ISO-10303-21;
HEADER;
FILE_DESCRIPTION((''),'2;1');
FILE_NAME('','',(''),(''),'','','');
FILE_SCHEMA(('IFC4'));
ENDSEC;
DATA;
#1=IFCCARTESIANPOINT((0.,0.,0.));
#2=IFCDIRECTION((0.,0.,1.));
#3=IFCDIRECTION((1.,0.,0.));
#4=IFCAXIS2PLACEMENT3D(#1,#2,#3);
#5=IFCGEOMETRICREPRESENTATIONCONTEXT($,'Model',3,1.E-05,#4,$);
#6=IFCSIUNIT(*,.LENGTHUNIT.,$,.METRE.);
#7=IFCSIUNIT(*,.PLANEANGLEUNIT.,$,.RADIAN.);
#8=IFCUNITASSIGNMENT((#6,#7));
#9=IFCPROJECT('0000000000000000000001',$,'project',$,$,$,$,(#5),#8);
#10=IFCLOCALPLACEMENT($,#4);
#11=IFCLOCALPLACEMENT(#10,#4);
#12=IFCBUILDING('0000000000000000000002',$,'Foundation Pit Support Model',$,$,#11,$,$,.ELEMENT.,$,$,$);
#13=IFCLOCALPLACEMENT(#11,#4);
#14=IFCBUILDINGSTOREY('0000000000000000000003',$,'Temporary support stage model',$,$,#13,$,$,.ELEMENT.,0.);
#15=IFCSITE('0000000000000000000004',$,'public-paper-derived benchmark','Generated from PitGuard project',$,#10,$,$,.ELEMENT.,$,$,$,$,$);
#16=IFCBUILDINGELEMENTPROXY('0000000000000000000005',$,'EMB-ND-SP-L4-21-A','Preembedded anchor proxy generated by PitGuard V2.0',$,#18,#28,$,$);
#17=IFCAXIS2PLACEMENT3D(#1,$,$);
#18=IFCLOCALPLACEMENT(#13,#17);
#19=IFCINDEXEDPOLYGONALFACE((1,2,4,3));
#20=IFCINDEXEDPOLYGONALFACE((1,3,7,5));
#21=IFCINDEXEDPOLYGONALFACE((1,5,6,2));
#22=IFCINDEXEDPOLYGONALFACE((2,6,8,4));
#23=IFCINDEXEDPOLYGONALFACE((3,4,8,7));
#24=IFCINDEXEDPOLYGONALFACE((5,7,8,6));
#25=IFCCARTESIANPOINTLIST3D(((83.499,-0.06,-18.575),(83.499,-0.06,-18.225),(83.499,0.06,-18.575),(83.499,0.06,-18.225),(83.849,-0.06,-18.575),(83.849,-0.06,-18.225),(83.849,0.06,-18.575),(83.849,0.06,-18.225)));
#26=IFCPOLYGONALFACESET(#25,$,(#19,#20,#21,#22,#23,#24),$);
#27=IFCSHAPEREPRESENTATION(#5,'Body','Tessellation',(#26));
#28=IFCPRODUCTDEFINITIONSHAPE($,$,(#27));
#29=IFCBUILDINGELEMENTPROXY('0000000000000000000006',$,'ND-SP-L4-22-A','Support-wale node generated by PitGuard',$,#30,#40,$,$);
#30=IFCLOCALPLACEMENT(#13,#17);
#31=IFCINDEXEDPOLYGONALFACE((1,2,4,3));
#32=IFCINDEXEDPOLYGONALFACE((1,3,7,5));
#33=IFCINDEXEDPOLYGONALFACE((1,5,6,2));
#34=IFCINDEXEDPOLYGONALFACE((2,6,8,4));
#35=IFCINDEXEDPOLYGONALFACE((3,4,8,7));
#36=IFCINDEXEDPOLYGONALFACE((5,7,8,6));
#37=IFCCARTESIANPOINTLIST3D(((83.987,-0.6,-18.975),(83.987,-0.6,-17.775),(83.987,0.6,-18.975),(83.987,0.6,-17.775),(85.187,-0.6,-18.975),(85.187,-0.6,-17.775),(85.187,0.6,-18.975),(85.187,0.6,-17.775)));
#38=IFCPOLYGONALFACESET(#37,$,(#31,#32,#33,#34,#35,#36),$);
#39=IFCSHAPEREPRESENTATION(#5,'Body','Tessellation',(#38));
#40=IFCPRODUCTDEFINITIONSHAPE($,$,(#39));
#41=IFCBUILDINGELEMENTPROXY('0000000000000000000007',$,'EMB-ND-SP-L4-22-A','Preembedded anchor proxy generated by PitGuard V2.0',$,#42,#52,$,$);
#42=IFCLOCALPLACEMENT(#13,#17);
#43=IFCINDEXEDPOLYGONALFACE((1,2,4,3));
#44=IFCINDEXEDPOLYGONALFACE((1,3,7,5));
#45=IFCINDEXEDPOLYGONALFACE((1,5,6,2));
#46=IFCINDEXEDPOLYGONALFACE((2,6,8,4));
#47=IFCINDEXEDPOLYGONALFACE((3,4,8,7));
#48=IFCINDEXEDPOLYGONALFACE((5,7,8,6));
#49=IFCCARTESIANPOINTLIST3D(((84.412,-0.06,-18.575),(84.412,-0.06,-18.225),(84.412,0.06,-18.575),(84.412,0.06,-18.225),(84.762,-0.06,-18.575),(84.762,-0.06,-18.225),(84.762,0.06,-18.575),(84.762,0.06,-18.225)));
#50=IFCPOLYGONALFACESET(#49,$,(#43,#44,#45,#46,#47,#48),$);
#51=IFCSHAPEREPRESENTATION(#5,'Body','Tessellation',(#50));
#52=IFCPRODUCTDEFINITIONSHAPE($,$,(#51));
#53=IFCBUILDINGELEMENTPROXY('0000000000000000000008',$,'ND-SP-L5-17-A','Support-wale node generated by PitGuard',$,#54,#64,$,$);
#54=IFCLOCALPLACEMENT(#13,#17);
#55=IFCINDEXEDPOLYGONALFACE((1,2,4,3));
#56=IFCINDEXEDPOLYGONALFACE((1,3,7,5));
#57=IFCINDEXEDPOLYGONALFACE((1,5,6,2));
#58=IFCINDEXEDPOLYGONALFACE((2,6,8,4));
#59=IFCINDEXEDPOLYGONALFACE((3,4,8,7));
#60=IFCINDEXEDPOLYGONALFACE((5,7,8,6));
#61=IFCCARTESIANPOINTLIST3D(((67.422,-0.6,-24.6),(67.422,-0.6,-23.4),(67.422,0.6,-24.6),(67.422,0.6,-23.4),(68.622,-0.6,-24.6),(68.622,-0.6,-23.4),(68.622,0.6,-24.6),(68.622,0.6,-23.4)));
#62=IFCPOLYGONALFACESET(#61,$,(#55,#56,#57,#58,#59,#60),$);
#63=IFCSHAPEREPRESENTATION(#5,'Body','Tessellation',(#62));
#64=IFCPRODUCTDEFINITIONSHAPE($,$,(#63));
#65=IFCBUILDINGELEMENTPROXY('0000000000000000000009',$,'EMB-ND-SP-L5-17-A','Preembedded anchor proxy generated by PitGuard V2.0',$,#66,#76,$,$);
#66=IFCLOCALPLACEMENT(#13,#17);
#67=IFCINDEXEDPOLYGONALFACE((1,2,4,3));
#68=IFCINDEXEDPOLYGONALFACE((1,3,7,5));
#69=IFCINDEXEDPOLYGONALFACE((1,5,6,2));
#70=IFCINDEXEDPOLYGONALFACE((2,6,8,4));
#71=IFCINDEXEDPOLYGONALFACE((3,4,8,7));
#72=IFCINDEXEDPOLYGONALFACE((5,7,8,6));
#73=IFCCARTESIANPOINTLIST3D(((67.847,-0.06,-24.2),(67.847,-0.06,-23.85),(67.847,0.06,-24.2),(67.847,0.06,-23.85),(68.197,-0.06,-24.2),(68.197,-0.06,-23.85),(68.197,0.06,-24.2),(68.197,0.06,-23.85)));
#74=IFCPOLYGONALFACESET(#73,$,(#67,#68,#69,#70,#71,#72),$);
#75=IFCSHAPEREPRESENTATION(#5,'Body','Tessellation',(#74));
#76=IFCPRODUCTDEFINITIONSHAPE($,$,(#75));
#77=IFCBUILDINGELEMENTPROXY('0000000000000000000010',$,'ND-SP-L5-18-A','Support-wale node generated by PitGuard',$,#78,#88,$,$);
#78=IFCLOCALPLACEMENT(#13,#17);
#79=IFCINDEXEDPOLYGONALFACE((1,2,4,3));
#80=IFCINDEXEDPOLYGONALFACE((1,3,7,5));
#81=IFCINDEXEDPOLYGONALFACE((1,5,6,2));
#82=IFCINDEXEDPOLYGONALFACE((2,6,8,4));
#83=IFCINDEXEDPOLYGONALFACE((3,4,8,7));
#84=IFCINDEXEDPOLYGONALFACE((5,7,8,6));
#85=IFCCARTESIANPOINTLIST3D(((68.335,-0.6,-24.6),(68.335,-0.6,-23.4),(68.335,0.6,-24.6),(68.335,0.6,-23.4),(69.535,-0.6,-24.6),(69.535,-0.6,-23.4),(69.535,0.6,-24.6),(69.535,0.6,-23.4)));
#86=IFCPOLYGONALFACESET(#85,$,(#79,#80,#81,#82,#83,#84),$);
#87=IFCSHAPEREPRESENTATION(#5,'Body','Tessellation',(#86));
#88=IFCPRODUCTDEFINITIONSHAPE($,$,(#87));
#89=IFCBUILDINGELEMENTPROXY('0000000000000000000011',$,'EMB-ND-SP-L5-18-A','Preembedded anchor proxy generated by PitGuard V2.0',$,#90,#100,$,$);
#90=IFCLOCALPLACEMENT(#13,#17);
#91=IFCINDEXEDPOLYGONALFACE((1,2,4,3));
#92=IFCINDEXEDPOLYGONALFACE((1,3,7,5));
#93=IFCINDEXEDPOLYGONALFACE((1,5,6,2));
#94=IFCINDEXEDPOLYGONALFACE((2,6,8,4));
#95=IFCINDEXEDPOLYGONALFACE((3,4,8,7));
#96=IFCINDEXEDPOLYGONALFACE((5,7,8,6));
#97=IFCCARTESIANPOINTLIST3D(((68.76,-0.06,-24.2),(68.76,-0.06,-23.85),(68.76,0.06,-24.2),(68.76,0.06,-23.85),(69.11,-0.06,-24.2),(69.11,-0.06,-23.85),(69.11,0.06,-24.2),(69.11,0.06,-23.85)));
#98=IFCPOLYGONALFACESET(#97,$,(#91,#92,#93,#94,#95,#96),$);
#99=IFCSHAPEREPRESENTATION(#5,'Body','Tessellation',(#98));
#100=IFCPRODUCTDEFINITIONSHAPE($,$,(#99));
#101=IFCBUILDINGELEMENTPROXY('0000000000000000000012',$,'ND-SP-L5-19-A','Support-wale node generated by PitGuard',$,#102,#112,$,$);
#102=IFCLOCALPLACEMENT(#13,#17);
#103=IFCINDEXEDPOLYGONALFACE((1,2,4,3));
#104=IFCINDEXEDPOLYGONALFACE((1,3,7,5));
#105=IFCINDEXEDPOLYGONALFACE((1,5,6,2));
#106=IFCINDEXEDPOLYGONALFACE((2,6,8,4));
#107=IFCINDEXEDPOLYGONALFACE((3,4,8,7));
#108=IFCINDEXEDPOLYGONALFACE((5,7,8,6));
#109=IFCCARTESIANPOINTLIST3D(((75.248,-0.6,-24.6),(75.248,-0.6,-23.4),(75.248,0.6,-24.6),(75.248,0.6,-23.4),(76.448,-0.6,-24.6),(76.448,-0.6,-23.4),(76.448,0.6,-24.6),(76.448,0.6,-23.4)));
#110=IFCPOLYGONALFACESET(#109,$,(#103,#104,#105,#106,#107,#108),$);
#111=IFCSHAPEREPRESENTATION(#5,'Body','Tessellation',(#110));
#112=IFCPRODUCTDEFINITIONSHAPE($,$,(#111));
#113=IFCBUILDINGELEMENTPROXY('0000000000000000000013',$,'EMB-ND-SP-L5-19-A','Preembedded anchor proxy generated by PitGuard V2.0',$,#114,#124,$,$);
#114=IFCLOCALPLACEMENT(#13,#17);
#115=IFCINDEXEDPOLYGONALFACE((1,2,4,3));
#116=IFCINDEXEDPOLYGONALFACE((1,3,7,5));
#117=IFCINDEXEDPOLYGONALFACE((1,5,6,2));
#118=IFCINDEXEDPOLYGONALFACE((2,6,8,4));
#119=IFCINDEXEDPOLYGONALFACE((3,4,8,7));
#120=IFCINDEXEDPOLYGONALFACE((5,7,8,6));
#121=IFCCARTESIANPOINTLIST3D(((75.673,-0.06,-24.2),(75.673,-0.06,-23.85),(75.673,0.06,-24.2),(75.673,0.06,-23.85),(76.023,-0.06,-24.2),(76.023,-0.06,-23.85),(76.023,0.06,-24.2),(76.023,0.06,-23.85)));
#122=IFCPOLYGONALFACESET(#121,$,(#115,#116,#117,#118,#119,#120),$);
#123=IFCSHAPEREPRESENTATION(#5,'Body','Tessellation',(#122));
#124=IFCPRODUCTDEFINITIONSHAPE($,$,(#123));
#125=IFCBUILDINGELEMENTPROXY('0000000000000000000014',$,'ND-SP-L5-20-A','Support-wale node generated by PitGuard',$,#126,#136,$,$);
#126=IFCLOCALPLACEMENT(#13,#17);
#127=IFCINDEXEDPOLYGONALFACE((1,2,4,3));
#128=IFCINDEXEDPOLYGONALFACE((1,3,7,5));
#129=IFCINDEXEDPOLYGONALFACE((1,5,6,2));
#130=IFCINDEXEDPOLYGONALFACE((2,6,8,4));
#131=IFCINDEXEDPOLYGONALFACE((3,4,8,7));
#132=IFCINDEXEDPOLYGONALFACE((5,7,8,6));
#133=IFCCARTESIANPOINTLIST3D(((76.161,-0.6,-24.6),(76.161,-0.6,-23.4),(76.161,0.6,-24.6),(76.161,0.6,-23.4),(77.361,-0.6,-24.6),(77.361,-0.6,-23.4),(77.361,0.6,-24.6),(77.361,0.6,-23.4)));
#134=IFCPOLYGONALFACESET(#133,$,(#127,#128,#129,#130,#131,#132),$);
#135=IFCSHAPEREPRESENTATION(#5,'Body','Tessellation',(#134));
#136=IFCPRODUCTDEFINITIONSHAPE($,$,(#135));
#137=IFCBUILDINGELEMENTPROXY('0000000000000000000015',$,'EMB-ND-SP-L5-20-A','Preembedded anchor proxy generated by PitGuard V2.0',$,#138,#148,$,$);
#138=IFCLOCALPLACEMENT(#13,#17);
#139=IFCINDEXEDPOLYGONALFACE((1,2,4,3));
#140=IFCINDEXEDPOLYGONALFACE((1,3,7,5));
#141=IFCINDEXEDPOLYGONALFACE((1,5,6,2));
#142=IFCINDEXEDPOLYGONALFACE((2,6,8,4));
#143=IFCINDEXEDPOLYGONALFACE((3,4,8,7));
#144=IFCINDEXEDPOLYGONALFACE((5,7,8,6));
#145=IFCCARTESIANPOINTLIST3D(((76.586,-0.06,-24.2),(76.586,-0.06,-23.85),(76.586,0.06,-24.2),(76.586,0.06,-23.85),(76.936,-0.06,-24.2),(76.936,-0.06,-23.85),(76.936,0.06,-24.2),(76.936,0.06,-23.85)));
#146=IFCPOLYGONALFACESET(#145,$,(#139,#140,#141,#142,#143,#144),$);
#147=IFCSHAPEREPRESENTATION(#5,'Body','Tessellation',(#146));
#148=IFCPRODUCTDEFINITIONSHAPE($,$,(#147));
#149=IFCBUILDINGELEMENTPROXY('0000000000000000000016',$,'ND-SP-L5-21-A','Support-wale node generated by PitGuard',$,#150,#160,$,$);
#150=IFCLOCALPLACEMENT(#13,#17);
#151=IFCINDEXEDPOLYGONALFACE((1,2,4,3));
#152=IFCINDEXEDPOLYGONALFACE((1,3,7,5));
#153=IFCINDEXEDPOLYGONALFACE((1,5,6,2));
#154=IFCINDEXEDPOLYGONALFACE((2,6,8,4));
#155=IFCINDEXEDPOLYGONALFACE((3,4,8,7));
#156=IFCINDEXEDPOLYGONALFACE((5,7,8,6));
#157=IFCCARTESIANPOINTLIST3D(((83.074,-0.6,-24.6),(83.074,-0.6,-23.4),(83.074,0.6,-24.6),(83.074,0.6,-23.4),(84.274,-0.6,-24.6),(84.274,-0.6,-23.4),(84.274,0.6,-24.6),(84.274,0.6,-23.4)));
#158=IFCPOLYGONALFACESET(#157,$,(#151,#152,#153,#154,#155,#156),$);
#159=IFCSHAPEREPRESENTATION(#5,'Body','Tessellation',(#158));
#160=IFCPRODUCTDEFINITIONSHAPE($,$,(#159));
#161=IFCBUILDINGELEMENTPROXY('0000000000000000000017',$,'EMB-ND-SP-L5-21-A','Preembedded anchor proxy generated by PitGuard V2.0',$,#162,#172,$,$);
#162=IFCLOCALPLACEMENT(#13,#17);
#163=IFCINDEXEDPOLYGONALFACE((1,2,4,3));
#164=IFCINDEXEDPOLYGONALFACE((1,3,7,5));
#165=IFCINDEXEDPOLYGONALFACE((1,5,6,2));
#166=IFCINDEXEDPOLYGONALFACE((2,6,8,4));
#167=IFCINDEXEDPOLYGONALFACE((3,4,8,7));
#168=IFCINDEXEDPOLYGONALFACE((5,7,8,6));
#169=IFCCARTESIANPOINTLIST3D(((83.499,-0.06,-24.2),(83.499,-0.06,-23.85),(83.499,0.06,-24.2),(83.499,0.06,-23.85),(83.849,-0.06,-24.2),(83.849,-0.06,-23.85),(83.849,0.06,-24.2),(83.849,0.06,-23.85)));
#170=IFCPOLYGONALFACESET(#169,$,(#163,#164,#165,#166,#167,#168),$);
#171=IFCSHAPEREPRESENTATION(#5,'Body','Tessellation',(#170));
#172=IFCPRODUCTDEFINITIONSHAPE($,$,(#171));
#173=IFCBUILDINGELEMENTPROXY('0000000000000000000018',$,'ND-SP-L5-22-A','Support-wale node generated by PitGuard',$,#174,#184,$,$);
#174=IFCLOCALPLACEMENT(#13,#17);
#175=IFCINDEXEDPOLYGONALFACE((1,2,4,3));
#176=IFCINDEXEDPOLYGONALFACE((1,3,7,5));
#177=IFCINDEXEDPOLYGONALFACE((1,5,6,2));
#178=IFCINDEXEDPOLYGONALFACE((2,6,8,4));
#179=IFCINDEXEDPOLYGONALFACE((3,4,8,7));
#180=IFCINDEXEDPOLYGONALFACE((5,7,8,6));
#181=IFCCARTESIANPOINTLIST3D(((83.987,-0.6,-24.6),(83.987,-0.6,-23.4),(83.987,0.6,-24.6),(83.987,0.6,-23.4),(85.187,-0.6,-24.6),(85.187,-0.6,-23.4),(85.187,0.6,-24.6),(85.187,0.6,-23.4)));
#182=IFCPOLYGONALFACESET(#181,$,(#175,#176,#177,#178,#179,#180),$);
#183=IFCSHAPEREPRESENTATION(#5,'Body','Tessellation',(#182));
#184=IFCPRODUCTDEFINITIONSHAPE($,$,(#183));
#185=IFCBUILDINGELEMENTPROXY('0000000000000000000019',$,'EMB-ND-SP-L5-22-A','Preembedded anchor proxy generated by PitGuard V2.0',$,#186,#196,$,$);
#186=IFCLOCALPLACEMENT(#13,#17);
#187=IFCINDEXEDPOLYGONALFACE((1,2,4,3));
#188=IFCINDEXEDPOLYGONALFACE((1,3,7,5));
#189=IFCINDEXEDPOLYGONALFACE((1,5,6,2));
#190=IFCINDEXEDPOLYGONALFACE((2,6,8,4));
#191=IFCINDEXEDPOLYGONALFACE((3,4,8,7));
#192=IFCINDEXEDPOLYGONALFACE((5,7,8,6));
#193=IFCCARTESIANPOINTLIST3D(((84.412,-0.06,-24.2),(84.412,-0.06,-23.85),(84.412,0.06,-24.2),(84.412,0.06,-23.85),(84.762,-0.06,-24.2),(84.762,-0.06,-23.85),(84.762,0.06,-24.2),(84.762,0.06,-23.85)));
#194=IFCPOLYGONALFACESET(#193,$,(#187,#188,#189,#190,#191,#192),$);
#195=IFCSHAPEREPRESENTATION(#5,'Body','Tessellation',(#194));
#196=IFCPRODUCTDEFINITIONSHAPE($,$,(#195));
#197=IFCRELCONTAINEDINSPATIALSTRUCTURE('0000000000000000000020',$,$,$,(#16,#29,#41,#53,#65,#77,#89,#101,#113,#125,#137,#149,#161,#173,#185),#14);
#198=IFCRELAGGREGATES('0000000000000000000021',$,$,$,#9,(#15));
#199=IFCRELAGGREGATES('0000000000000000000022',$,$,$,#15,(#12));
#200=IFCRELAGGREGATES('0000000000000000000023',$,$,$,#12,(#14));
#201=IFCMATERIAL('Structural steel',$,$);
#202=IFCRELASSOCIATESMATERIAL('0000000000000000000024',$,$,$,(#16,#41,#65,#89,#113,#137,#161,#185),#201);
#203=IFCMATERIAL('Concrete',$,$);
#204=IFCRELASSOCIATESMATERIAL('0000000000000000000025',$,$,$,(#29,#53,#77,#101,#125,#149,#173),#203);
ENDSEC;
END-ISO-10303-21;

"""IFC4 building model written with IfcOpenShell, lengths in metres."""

from ifc_helpers import new_model, si_unit, frame, origin_with_axes, origin_2d, place, context, project, spatial, rectangle, extrude, material, element, save


model = new_model("IFC4")

# Units and contexts
model_context = context("Model", 3, precision=1e-05, world=origin_with_axes())
ifc_project = project(units=[si_unit("LENGTHUNIT", "METRE"), si_unit("PLANEANGLEUNIT", "RADIAN")], contexts=[model_context])

# Site, building, storey
site_placement = place(None, origin_with_axes())
site = spatial("IfcSite", under=ifc_project, at=site_placement, Name="public-paper-derived benchmark", Description="Generated from PitGuard project", CompositionType="ELEMENT")
building_placement = place(site_placement, origin_with_axes())
building = spatial("IfcBuilding", under=site, at=building_placement, Name="Foundation Pit Support Model", CompositionType="ELEMENT")
storey_placement = place(building_placement, origin_with_axes())
storey = spatial("IfcBuildingStorey", under=building, at=storey_placement, Name="Temporary support stage model", CompositionType="ELEMENT", Elevation=0.0)

# Shared definitions
ifc_material_1 = material(Name="Structural steel")

# Building element proxies
ifc_material_2 = material(Name="Concrete")
proxy_1_placement = place(storey_placement, frame((83.674, 0.0, -18.575), z_axis=(0.0, 0.0, 1.0), x_axis=(1.0, 0.0, 0.0)))
element("IfcBuildingElementProxy", 1, at=proxy_1_placement, inside=storey, material=ifc_material_1, Name="EMB-ND-SP-L4-21-A", Description="Preembedded anchor proxy generated by PitGuard V2.0", context=model_context, shape_type="SweptSolid", body=[
    extrude(rectangle(XDim=0.35, YDim=0.12, at=origin_2d()), origin_with_axes(), (0.0, 0.0, 1.0), 0.35),
])
proxy_2_placement = place(storey_placement, frame((84.587, 0.0, -18.975), z_axis=(0.0, 0.0, 1.0), x_axis=(1.0, 0.0, 0.0)))
element("IfcBuildingElementProxy", 2, at=proxy_2_placement, inside=storey, material=ifc_material_2, Name="ND-SP-L4-22-A", Description="Support-wale node generated by PitGuard", context=model_context, shape_type="SweptSolid", body=[
    extrude(rectangle(XDim=1.2, YDim=1.2, at=origin_2d()), origin_with_axes(), (0.0, 0.0, 1.0), 1.2),
])
proxy_3_placement = place(storey_placement, frame((84.587, 0.0, -18.575), z_axis=(0.0, 0.0, 1.0), x_axis=(1.0, 0.0, 0.0)))
element("IfcBuildingElementProxy", 3, at=proxy_3_placement, inside=storey, material=ifc_material_1, Name="EMB-ND-SP-L4-22-A", Description="Preembedded anchor proxy generated by PitGuard V2.0", context=model_context, shape_type="SweptSolid", body=[
    extrude(rectangle(XDim=0.35, YDim=0.12, at=origin_2d()), origin_with_axes(), (0.0, 0.0, 1.0), 0.35),
])
proxy_4_placement = place(storey_placement, frame((68.022, 0.0, -24.6), z_axis=(0.0, 0.0, 1.0), x_axis=(1.0, 0.0, 0.0)))
element("IfcBuildingElementProxy", 4, at=proxy_4_placement, inside=storey, material=ifc_material_2, Name="ND-SP-L5-17-A", Description="Support-wale node generated by PitGuard", context=model_context, shape_type="SweptSolid", body=[
    extrude(rectangle(XDim=1.2, YDim=1.2, at=origin_2d()), origin_with_axes(), (0.0, 0.0, 1.0), 1.2),
])
proxy_5_placement = place(storey_placement, frame((68.022, 0.0, -24.2), z_axis=(0.0, 0.0, 1.0), x_axis=(1.0, 0.0, 0.0)))
element("IfcBuildingElementProxy", 5, at=proxy_5_placement, inside=storey, material=ifc_material_1, Name="EMB-ND-SP-L5-17-A", Description="Preembedded anchor proxy generated by PitGuard V2.0", context=model_context, shape_type="SweptSolid", body=[
    extrude(rectangle(XDim=0.35, YDim=0.12, at=origin_2d()), origin_with_axes(), (0.0, 0.0, 1.0), 0.35),
])
proxy_6_placement = place(storey_placement, frame((68.935, 0.0, -24.6), z_axis=(0.0, 0.0, 1.0), x_axis=(1.0, 0.0, 0.0)))
element("IfcBuildingElementProxy", 6, at=proxy_6_placement, inside=storey, material=ifc_material_2, Name="ND-SP-L5-18-A", Description="Support-wale node generated by PitGuard", context=model_context, shape_type="SweptSolid", body=[
    extrude(rectangle(XDim=1.2, YDim=1.2, at=origin_2d()), origin_with_axes(), (0.0, 0.0, 1.0), 1.2),
])
proxy_7_placement = place(storey_placement, frame((68.935, 0.0, -24.2), z_axis=(0.0, 0.0, 1.0), x_axis=(1.0, 0.0, 0.0)))
element("IfcBuildingElementProxy", 7, at=proxy_7_placement, inside=storey, material=ifc_material_1, Name="EMB-ND-SP-L5-18-A", Description="Preembedded anchor proxy generated by PitGuard V2.0", context=model_context, shape_type="SweptSolid", body=[
    extrude(rectangle(XDim=0.35, YDim=0.12, at=origin_2d()), origin_with_axes(), (0.0, 0.0, 1.0), 0.35),
])
proxy_8_placement = place(storey_placement, frame((75.848, 0.0, -24.6), z_axis=(0.0, 0.0, 1.0), x_axis=(1.0, 0.0, 0.0)))
element("IfcBuildingElementProxy", 8, at=proxy_8_placement, inside=storey, material=ifc_material_2, Name="ND-SP-L5-19-A", Description="Support-wale node generated by PitGuard", context=model_context, shape_type="SweptSolid", body=[
    extrude(rectangle(XDim=1.2, YDim=1.2, at=origin_2d()), origin_with_axes(), (0.0, 0.0, 1.0), 1.2),
])
proxy_9_placement = place(storey_placement, frame((75.848, 0.0, -24.2), z_axis=(0.0, 0.0, 1.0), x_axis=(1.0, 0.0, 0.0)))
element("IfcBuildingElementProxy", 9, at=proxy_9_placement, inside=storey, material=ifc_material_1, Name="EMB-ND-SP-L5-19-A", Description="Preembedded anchor proxy generated by PitGuard V2.0", context=model_context, shape_type="SweptSolid", body=[
    extrude(rectangle(XDim=0.35, YDim=0.12, at=origin_2d()), origin_with_axes(), (0.0, 0.0, 1.0), 0.35),
])
proxy_10_placement = place(storey_placement, frame((76.761, 0.0, -24.6), z_axis=(0.0, 0.0, 1.0), x_axis=(1.0, 0.0, 0.0)))
element("IfcBuildingElementProxy", 10, at=proxy_10_placement, inside=storey, material=ifc_material_2, Name="ND-SP-L5-20-A", Description="Support-wale node generated by PitGuard", context=model_context, shape_type="SweptSolid", body=[
    extrude(rectangle(XDim=1.2, YDim=1.2, at=origin_2d()), origin_with_axes(), (0.0, 0.0, 1.0), 1.2),
])
proxy_11_placement = place(storey_placement, frame((76.761, 0.0, -24.2), z_axis=(0.0, 0.0, 1.0), x_axis=(1.0, 0.0, 0.0)))
element("IfcBuildingElementProxy", 11, at=proxy_11_placement, inside=storey, material=ifc_material_1, Name="EMB-ND-SP-L5-20-A", Description="Preembedded anchor proxy generated by PitGuard V2.0", context=model_context, shape_type="SweptSolid", body=[
    extrude(rectangle(XDim=0.35, YDim=0.12, at=origin_2d()), origin_with_axes(), (0.0, 0.0, 1.0), 0.35),
])
proxy_12_placement = place(storey_placement, frame((83.674, 0.0, -24.6), z_axis=(0.0, 0.0, 1.0), x_axis=(1.0, 0.0, 0.0)))
element("IfcBuildingElementProxy", 12, at=proxy_12_placement, inside=storey, material=ifc_material_2, Name="ND-SP-L5-21-A", Description="Support-wale node generated by PitGuard", context=model_context, shape_type="SweptSolid", body=[
    extrude(rectangle(XDim=1.2, YDim=1.2, at=origin_2d()), origin_with_axes(), (0.0, 0.0, 1.0), 1.2),
])
proxy_13_placement = place(storey_placement, frame((83.674, 0.0, -24.2), z_axis=(0.0, 0.0, 1.0), x_axis=(1.0, 0.0, 0.0)))
element("IfcBuildingElementProxy", 13, at=proxy_13_placement, inside=storey, material=ifc_material_1, Name="EMB-ND-SP-L5-21-A", Description="Preembedded anchor proxy generated by PitGuard V2.0", context=model_context, shape_type="SweptSolid", body=[
    extrude(rectangle(XDim=0.35, YDim=0.12, at=origin_2d()), origin_with_axes(), (0.0, 0.0, 1.0), 0.35),
])
proxy_14_placement = place(storey_placement, frame((84.587, 0.0, -24.6), z_axis=(0.0, 0.0, 1.0), x_axis=(1.0, 0.0, 0.0)))
element("IfcBuildingElementProxy", 14, at=proxy_14_placement, inside=storey, material=ifc_material_2, Name="ND-SP-L5-22-A", Description="Support-wale node generated by PitGuard", context=model_context, shape_type="SweptSolid", body=[
    extrude(rectangle(XDim=1.2, YDim=1.2, at=origin_2d()), origin_with_axes(), (0.0, 0.0, 1.0), 1.2),
])
proxy_15_placement = place(storey_placement, frame((84.587, 0.0, -24.2), z_axis=(0.0, 0.0, 1.0), x_axis=(1.0, 0.0, 0.0)))
element("IfcBuildingElementProxy", 15, at=proxy_15_placement, inside=storey, material=ifc_material_1, Name="EMB-ND-SP-L5-22-A", Description="Preembedded anchor proxy generated by PitGuard V2.0", context=model_context, shape_type="SweptSolid", body=[
    extrude(rectangle(XDim=0.35, YDim=0.12, at=origin_2d()), origin_with_axes(), (0.0, 0.0, 1.0), 0.35),
])

save(model, "model.ifc")
